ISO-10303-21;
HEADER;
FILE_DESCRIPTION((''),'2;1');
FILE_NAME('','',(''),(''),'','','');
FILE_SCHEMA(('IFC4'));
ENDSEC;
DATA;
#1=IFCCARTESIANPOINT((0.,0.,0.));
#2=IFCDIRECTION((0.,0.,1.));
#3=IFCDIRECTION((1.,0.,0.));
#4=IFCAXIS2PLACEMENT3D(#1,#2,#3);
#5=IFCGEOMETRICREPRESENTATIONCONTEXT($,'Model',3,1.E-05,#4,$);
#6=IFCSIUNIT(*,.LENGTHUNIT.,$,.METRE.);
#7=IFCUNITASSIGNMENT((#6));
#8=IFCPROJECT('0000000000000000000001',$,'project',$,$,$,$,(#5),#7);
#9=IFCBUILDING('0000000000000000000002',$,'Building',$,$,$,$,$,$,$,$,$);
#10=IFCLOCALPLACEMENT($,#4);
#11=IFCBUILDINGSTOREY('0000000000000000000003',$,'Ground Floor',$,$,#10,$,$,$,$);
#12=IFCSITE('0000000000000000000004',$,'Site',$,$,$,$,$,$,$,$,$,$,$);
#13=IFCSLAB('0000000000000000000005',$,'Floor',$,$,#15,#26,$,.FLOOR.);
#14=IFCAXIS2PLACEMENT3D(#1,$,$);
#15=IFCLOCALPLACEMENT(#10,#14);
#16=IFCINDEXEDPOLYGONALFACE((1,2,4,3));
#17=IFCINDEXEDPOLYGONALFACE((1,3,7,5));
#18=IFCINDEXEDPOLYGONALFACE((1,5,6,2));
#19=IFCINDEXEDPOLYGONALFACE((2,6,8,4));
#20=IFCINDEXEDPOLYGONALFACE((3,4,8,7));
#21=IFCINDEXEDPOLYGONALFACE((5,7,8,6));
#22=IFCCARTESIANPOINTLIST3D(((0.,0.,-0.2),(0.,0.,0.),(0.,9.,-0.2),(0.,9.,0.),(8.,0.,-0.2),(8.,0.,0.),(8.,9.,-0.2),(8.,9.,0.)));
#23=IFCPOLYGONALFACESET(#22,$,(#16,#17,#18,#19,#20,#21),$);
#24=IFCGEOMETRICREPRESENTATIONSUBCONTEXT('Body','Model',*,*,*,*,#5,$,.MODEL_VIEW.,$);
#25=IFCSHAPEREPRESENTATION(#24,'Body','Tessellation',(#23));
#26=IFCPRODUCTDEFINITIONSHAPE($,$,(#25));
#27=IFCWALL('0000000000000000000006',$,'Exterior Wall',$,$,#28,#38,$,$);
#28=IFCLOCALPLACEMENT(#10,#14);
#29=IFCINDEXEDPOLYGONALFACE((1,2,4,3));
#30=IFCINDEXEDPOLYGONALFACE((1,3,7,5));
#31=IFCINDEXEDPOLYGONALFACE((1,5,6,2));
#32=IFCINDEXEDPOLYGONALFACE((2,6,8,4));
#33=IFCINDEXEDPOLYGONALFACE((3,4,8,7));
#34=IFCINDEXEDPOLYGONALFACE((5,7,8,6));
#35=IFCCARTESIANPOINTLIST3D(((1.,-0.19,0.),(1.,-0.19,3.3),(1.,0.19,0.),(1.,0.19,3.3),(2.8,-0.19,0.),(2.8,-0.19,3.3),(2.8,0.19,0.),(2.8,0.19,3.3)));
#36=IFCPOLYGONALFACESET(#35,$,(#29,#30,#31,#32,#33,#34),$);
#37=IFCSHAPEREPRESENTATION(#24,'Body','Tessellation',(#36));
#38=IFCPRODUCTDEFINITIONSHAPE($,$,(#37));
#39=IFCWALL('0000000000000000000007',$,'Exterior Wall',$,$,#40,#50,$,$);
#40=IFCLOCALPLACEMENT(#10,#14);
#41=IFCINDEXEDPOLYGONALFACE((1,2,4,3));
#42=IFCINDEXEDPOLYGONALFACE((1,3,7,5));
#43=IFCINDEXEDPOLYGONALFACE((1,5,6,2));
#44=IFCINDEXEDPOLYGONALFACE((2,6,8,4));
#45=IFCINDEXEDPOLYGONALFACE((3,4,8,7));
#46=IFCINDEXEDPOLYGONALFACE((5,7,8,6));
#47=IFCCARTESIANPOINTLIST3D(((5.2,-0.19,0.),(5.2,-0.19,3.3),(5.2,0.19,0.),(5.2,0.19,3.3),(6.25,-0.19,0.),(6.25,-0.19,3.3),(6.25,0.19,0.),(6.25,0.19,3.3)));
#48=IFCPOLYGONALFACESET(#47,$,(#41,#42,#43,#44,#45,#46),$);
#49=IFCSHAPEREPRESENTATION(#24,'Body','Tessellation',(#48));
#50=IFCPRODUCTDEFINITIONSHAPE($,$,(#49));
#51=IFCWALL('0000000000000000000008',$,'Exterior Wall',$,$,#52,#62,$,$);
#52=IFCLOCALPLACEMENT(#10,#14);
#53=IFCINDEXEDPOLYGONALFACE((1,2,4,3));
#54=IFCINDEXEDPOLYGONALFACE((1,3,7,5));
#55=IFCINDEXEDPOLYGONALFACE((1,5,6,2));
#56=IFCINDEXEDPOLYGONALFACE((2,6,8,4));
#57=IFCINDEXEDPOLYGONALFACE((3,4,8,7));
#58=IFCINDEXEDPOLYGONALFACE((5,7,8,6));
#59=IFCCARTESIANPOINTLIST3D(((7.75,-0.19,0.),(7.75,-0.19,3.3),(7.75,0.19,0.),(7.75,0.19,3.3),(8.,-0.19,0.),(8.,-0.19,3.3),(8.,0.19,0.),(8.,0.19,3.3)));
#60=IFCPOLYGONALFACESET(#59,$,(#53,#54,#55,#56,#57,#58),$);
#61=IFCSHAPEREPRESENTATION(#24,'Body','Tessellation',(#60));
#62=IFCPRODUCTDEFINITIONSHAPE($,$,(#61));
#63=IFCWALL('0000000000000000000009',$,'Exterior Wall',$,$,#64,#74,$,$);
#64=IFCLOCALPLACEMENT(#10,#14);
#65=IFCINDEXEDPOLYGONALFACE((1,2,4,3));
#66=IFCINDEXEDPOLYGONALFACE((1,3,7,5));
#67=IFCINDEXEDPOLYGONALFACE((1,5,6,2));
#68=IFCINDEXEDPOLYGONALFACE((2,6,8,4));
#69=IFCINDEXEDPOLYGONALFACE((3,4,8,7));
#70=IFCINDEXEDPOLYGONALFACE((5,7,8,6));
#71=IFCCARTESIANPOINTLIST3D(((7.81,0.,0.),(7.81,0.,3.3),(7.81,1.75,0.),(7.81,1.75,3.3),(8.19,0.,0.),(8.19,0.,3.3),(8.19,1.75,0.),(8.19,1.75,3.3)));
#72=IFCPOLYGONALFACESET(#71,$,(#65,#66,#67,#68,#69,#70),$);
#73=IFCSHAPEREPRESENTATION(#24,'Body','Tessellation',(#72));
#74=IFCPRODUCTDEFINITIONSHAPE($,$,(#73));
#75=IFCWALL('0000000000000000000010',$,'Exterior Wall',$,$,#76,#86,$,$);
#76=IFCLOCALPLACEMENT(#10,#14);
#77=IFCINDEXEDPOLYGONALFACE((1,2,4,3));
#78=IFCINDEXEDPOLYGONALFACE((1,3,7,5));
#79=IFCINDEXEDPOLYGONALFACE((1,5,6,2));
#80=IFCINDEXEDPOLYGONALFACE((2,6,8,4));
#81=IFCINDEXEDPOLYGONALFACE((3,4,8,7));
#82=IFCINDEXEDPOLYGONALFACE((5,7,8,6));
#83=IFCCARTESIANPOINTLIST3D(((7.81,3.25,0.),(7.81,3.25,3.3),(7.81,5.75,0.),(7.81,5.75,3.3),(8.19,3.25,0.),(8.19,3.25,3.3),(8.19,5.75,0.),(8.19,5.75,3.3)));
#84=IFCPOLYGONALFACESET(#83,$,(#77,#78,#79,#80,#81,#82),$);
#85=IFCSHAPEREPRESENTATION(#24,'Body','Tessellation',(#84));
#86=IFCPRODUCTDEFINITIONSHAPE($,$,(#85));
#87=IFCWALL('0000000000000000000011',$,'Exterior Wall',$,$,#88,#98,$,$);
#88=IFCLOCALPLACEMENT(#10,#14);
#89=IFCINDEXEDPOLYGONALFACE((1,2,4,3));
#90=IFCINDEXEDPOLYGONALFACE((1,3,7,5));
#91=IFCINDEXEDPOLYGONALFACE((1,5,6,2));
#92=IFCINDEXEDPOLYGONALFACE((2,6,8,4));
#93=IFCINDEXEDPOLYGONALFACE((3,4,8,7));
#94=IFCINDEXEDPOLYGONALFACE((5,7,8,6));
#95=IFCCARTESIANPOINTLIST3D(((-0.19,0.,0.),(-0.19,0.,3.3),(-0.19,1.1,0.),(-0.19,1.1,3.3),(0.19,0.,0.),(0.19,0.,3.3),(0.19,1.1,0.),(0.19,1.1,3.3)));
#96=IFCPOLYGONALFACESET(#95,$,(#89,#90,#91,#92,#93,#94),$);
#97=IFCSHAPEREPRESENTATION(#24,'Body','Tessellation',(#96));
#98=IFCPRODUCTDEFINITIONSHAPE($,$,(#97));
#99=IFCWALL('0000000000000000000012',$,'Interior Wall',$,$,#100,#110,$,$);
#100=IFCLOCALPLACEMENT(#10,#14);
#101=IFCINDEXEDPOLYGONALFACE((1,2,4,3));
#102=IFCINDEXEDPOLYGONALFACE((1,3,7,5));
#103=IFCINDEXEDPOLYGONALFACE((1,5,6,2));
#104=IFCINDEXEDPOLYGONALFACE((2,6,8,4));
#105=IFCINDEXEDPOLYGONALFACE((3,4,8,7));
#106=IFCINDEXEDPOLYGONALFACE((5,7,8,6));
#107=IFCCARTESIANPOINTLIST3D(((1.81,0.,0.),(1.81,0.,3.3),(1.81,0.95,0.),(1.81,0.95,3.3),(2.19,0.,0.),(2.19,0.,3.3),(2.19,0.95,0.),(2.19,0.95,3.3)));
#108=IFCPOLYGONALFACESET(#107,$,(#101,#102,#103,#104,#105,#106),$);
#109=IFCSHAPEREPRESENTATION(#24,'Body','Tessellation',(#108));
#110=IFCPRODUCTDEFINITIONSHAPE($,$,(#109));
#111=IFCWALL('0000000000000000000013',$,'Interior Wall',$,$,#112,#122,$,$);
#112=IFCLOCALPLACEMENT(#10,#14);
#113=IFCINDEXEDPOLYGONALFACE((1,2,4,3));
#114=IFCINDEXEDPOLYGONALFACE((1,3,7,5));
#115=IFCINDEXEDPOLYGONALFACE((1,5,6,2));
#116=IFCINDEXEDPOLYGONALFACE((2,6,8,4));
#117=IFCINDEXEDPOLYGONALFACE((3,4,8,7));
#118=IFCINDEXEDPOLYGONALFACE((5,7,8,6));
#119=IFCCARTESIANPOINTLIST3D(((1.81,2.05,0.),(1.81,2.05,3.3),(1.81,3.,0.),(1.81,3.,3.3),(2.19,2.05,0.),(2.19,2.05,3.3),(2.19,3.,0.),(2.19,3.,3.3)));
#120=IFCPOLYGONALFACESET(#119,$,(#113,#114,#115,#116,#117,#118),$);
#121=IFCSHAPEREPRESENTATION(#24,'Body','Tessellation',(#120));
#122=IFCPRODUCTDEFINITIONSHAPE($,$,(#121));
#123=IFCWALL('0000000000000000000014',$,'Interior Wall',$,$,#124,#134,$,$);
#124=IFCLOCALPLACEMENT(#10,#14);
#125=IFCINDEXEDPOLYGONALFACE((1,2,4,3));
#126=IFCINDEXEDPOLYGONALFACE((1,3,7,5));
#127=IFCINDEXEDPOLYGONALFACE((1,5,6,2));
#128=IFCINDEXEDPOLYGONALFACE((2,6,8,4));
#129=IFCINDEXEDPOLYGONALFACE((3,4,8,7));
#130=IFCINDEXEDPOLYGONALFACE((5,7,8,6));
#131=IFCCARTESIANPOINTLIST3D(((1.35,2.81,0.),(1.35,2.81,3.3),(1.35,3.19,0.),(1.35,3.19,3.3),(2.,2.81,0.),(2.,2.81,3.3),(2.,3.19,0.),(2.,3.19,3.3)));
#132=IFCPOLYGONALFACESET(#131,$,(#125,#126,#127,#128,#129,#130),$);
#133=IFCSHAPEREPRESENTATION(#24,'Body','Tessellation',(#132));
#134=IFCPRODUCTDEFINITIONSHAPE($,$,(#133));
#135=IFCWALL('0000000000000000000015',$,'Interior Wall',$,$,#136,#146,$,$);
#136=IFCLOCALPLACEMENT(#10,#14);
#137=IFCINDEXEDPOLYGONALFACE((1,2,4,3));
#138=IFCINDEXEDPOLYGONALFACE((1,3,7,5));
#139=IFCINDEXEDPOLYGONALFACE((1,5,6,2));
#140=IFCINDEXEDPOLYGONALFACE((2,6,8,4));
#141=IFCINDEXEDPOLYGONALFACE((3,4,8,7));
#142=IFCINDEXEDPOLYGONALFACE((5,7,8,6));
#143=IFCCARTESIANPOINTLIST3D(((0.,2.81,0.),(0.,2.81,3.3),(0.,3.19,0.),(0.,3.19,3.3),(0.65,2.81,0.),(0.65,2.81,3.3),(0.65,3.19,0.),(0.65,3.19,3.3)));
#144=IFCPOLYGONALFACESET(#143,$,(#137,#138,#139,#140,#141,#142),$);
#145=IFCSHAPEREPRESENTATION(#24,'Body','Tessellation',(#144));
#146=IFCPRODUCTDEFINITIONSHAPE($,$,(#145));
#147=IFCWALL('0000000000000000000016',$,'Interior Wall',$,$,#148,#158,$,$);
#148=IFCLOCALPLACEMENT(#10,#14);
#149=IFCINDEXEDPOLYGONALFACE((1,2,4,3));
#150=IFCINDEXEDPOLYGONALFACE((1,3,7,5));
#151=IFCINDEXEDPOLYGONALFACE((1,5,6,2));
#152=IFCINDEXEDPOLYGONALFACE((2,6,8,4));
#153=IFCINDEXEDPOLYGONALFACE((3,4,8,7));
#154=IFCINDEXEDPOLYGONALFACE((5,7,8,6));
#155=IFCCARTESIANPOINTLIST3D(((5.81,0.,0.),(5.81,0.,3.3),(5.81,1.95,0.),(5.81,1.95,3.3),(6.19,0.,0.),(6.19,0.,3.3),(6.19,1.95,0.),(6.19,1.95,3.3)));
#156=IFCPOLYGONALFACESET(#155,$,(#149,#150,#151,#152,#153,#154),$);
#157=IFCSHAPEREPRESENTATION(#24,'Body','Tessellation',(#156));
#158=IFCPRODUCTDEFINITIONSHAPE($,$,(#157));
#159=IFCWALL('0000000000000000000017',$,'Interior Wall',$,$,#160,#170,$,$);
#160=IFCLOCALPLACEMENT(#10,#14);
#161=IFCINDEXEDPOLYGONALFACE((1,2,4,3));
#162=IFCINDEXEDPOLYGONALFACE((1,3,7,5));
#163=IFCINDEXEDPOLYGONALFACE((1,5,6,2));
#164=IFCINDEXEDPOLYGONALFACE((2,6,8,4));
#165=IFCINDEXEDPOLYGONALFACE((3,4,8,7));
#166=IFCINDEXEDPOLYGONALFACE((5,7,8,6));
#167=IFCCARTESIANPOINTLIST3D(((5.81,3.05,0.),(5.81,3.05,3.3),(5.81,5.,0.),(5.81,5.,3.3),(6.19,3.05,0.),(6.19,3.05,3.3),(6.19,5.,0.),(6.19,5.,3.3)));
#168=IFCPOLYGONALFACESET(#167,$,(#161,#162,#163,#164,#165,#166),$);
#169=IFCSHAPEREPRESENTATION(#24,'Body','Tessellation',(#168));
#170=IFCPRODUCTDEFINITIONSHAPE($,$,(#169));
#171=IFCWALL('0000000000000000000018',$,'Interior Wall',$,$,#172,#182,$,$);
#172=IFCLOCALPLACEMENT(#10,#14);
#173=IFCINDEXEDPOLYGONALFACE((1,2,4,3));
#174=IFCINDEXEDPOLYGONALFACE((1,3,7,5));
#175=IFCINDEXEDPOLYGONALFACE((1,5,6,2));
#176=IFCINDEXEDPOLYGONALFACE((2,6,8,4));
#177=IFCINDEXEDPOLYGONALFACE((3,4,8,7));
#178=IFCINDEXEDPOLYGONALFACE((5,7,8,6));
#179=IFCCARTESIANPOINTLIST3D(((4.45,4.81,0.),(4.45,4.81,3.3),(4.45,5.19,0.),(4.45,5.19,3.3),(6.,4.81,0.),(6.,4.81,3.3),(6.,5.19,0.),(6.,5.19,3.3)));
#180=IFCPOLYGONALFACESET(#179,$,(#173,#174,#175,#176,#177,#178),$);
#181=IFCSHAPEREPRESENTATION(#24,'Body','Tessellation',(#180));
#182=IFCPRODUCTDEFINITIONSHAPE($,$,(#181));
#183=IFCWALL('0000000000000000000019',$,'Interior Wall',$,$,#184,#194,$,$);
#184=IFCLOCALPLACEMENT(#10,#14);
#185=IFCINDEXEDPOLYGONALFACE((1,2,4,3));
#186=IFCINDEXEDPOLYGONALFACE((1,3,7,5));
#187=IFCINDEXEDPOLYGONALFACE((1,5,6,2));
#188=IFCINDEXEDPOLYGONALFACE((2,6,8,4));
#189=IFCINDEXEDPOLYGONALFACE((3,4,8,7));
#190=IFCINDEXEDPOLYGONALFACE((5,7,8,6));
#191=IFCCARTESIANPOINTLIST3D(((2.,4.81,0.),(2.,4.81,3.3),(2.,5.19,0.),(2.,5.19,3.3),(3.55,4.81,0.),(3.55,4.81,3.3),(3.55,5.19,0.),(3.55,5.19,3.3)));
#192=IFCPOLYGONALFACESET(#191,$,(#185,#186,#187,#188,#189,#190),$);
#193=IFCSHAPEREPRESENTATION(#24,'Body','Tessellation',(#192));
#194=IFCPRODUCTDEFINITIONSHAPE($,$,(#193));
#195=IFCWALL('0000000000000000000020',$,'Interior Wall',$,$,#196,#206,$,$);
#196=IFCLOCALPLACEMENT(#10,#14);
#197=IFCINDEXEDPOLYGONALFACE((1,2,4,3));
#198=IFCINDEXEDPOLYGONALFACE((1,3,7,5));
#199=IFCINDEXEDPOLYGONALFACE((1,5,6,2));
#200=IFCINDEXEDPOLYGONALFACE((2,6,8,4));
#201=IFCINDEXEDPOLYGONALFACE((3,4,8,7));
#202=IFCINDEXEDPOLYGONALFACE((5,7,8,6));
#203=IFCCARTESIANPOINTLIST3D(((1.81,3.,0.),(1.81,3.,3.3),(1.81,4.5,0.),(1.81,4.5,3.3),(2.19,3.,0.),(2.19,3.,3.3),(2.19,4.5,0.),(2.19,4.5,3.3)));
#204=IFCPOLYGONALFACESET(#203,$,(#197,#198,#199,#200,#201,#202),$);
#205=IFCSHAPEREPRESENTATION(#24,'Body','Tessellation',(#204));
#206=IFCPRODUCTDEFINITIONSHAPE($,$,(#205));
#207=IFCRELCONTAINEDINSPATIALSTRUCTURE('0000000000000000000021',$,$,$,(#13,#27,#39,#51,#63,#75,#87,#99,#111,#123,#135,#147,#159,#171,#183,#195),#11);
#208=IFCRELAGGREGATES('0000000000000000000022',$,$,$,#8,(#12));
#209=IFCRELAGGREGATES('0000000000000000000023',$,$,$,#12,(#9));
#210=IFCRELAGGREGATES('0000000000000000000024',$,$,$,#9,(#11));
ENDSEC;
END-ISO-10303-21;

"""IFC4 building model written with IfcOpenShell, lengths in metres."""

from ifc_helpers import new_model, si_unit, frame, origin_with_axes, place, context, subcontext, project, spatial, indexed_curve, outline, extrude, element, save


model = new_model("IFC4")

# Units and contexts
model_context = context("Model", 3, precision=1e-05, world=origin_with_axes())
body_context = subcontext(model_context, "Body", "Model", "MODEL_VIEW")
ifc_project = project(units=[si_unit("LENGTHUNIT", "METRE")], contexts=[model_context])

# Site, building, storey
site = spatial("IfcSite", under=ifc_project, Name="Site")
building = spatial("IfcBuilding", under=site, Name="Building")
storey_placement = place(None, origin_with_axes())
storey = spatial("IfcBuildingStorey", under=building, at=storey_placement, Name="Ground Floor")

# Slab
slab_placement = place(storey_placement, frame((0.0, 0.0, -0.2), z_axis=(0.0, 0.0, 1.0), x_axis=(1.0, 0.0, 0.0)))
element("IfcSlab", 1, at=slab_placement, inside=storey, Name="Floor", PredefinedType="FLOOR", context=body_context, shape_type="SweptSolid", body=[
    extrude(outline(indexed_curve([(0.0, 0.0), (8.0, 0.0), (8.0, 9.0), (0.0, 9.0)])), None, (0.0, 0.0, 1.0), 0.2),
])

# Walls
wall_1_placement = place(storey_placement, frame((1.0, 0.0, 0.0), z_axis=(0.0, 0.0, 1.0), x_axis=(1.0, 0.0, 0.0)))
element("IfcWall", 2, at=wall_1_placement, inside=storey, Name="Exterior Wall", context=body_context, shape_type="SweptSolid", body=[
    extrude(outline(indexed_curve([(0.0, 0.0), (0.0, 0.38), (1.8, 0.38), (1.8, 0.0), (0.0, 0.0)], self_intersect=False)), frame((0.0, -0.19, 0.0), z_axis=(0.0, 0.0, 1.0), x_axis=(1.0, 0.0, 0.0)), (0.0, 0.0, 1.0), 3.3),
])
wall_2_placement = place(storey_placement, frame((5.2, 0.0, 0.0), z_axis=(0.0, 0.0, 1.0), x_axis=(1.0, 0.0, 0.0)))
element("IfcWall", 3, at=wall_2_placement, inside=storey, Name="Exterior Wall", context=body_context, shape_type="SweptSolid", body=[
    extrude(outline(indexed_curve([(0.0, 0.0), (0.0, 0.38), (1.05, 0.38), (1.05, 0.0), (0.0, 0.0)], self_intersect=False)), frame((0.0, -0.19, 0.0), z_axis=(0.0, 0.0, 1.0), x_axis=(1.0, 0.0, 0.0)), (0.0, 0.0, 1.0), 3.3),
])
wall_3_placement = place(storey_placement, frame((7.75, 0.0, 0.0), z_axis=(0.0, 0.0, 1.0), x_axis=(1.0, 0.0, 0.0)))
element("IfcWall", 4, at=wall_3_placement, inside=storey, Name="Exterior Wall", context=body_context, shape_type="SweptSolid", body=[
    extrude(outline(indexed_curve([(0.0, 0.0), (0.0, 0.38), (0.25, 0.38), (0.25, 0.0), (0.0, 0.0)], self_intersect=False)), frame((0.0, -0.19, 0.0), z_axis=(0.0, 0.0, 1.0), x_axis=(1.0, 0.0, 0.0)), (0.0, 0.0, 1.0), 3.3),
])
wall_4_placement = place(storey_placement, frame((8.0, 0.0, 0.0), z_axis=(0.0, 0.0, 1.0), x_axis=(0.0, 1.0, 0.0)))
element("IfcWall", 5, at=wall_4_placement, inside=storey, Name="Exterior Wall", context=body_context, shape_type="SweptSolid", body=[
    extrude(outline(indexed_curve([(0.0, 0.0), (0.0, 0.38), (1.75, 0.38), (1.75, 0.0), (0.0, 0.0)], self_intersect=False)), frame((0.0, -0.19, 0.0), z_axis=(0.0, 0.0, 1.0), x_axis=(1.0, 0.0, 0.0)), (0.0, 0.0, 1.0), 3.3),
])
wall_5_placement = place(storey_placement, frame((8.0, 3.25, 0.0), z_axis=(0.0, 0.0, 1.0), x_axis=(0.0, 1.0, 0.0)))
element("IfcWall", 6, at=wall_5_placement, inside=storey, Name="Exterior Wall", context=body_context, shape_type="SweptSolid", body=[
    extrude(outline(indexed_curve([(0.0, 0.0), (0.0, 0.38), (2.5, 0.38), (2.5, 0.0), (0.0, 0.0)], self_intersect=False)), frame((0.0, -0.19, 0.0), z_axis=(0.0, 0.0, 1.0), x_axis=(1.0, 0.0, 0.0)), (0.0, 0.0, 1.0), 3.3),
])
wall_6_placement = place(storey_placement, frame((0.0, 1.1, 0.0), z_axis=(0.0, 0.0, 1.0), x_axis=(0.0, -1.0, 0.0)))
element("IfcWall", 7, at=wall_6_placement, inside=storey, Name="Exterior Wall", context=body_context, shape_type="SweptSolid", body=[
    extrude(outline(indexed_curve([(0.0, 0.0), (0.0, 0.38), (1.1, 0.38), (1.1, 0.0), (0.0, 0.0)], self_intersect=False)), frame((0.0, -0.19, 0.0), z_axis=(0.0, 0.0, 1.0), x_axis=(1.0, 0.0, 0.0)), (0.0, 0.0, 1.0), 3.3),
])
wall_7_placement = place(storey_placement, frame((2.0, 0.0, 0.0), z_axis=(0.0, 0.0, 1.0), x_axis=(0.0, 1.0, 0.0)))
element("IfcWall", 8, at=wall_7_placement, inside=storey, Name="Interior Wall", context=body_context, shape_type="SweptSolid", body=[
    extrude(outline(indexed_curve([(0.0, 0.0), (0.0, 0.38), (0.95, 0.38), (0.95, 0.0), (0.0, 0.0)], self_intersect=False)), frame((0.0, -0.19, 0.0), z_axis=(0.0, 0.0, 1.0), x_axis=(1.0, 0.0, 0.0)), (0.0, 0.0, 1.0), 3.3),
])
wall_8_placement = place(storey_placement, frame((2.0, 2.05, 0.0), z_axis=(0.0, 0.0, 1.0), x_axis=(0.0, 1.0, 0.0)))
element("IfcWall", 9, at=wall_8_placement, inside=storey, Name="Interior Wall", context=body_context, shape_type="SweptSolid", body=[
    extrude(outline(indexed_curve([(0.0, 0.0), (0.0, 0.38), (0.95, 0.38), (0.95, 0.0), (0.0, 0.0)], self_intersect=False)), frame((0.0, -0.19, 0.0), z_axis=(0.0, 0.0, 1.0), x_axis=(1.0, 0.0, 0.0)), (0.0, 0.0, 1.0), 3.3),
])
for number, where, z_axis, x_axis, name in (
    (10, (2.0, 3.0, 0.0), (0.0, 0.0, 1.0), (-1.0, 0.0, 0.0), "Interior Wall"),
    (11, (0.65, 3.0, 0.0), (0.0, 0.0, 1.0), (-1.0, 0.0, 0.0), "Interior Wall"),
):
    element("IfcWall", number, at=place(storey_placement, frame(where, z_axis=z_axis, x_axis=x_axis)), inside=storey, Name=name, context=body_context, shape_type="SweptSolid", body=[
        extrude(outline(indexed_curve([(0.0, 0.0), (0.0, 0.38), (0.65, 0.38), (0.65, 0.0), (0.0, 0.0)], self_intersect=False)), frame((0.0, -0.19, 0.0), z_axis=(0.0, 0.0, 1.0), x_axis=(1.0, 0.0, 0.0)), (0.0, 0.0, 1.0), 3.3),
    ])
wall_9_placement = place(storey_placement, frame((6.0, 0.0, 0.0), z_axis=(0.0, 0.0, 1.0), x_axis=(0.0, 1.0, 0.0)))
element("IfcWall", 12, at=wall_9_placement, inside=storey, Name="Interior Wall", context=body_context, shape_type="SweptSolid", body=[
    extrude(outline(indexed_curve([(0.0, 0.0), (0.0, 0.38), (1.95, 0.38), (1.95, 0.0), (0.0, 0.0)], self_intersect=False)), frame((0.0, -0.19, 0.0), z_axis=(0.0, 0.0, 1.0), x_axis=(1.0, 0.0, 0.0)), (0.0, 0.0, 1.0), 3.3),
])
wall_10_placement = place(storey_placement, frame((6.0, 3.05, 0.0), z_axis=(0.0, 0.0, 1.0), x_axis=(0.0, 1.0, 0.0)))
element("IfcWall", 13, at=wall_10_placement, inside=storey, Name="Interior Wall", context=body_context, shape_type="SweptSolid", body=[
    extrude(outline(indexed_curve([(0.0, 0.0), (0.0, 0.38), (1.95, 0.38), (1.95, 0.0), (0.0, 0.0)], self_intersect=False)), frame((0.0, -0.19, 0.0), z_axis=(0.0, 0.0, 1.0), x_axis=(1.0, 0.0, 0.0)), (0.0, 0.0, 1.0), 3.3),
])
for number, where, z_axis, x_axis, name in (
    (14, (6.0, 5.0, 0.0), (0.0, 0.0, 1.0), (-1.0, 0.0, 0.0), "Interior Wall"),
    (15, (3.55, 5.0, 0.0), (0.0, 0.0, 1.0), (-1.0, 0.0, 0.0), "Interior Wall"),
):
    element("IfcWall", number, at=place(storey_placement, frame(where, z_axis=z_axis, x_axis=x_axis)), inside=storey, Name=name, context=body_context, shape_type="SweptSolid", body=[
        extrude(outline(indexed_curve([(0.0, 0.0), (0.0, 0.38), (1.55, 0.38), (1.55, 0.0), (0.0, 0.0)], self_intersect=False)), frame((0.0, -0.19, 0.0), z_axis=(0.0, 0.0, 1.0), x_axis=(1.0, 0.0, 0.0)), (0.0, 0.0, 1.0), 3.3),
    ])
wall_11_placement = place(storey_placement, frame((2.0, 4.5, 0.0), z_axis=(0.0, 0.0, 1.0), x_axis=(0.0, -1.0, 0.0)))
element("IfcWall", 16, at=wall_11_placement, inside=storey, Name="Interior Wall", context=body_context, shape_type="SweptSolid", body=[
    extrude(outline(indexed_curve([(0.0, 0.0), (0.0, 0.38), (1.5, 0.38), (1.5, 0.0), (0.0, 0.0)], self_intersect=False)), frame((0.0, -0.19, 0.0), z_axis=(0.0, 0.0, 1.0), x_axis=(1.0, 0.0, 0.0)), (0.0, 0.0, 1.0), 3.3),
])

save(model, "model.ifc")
